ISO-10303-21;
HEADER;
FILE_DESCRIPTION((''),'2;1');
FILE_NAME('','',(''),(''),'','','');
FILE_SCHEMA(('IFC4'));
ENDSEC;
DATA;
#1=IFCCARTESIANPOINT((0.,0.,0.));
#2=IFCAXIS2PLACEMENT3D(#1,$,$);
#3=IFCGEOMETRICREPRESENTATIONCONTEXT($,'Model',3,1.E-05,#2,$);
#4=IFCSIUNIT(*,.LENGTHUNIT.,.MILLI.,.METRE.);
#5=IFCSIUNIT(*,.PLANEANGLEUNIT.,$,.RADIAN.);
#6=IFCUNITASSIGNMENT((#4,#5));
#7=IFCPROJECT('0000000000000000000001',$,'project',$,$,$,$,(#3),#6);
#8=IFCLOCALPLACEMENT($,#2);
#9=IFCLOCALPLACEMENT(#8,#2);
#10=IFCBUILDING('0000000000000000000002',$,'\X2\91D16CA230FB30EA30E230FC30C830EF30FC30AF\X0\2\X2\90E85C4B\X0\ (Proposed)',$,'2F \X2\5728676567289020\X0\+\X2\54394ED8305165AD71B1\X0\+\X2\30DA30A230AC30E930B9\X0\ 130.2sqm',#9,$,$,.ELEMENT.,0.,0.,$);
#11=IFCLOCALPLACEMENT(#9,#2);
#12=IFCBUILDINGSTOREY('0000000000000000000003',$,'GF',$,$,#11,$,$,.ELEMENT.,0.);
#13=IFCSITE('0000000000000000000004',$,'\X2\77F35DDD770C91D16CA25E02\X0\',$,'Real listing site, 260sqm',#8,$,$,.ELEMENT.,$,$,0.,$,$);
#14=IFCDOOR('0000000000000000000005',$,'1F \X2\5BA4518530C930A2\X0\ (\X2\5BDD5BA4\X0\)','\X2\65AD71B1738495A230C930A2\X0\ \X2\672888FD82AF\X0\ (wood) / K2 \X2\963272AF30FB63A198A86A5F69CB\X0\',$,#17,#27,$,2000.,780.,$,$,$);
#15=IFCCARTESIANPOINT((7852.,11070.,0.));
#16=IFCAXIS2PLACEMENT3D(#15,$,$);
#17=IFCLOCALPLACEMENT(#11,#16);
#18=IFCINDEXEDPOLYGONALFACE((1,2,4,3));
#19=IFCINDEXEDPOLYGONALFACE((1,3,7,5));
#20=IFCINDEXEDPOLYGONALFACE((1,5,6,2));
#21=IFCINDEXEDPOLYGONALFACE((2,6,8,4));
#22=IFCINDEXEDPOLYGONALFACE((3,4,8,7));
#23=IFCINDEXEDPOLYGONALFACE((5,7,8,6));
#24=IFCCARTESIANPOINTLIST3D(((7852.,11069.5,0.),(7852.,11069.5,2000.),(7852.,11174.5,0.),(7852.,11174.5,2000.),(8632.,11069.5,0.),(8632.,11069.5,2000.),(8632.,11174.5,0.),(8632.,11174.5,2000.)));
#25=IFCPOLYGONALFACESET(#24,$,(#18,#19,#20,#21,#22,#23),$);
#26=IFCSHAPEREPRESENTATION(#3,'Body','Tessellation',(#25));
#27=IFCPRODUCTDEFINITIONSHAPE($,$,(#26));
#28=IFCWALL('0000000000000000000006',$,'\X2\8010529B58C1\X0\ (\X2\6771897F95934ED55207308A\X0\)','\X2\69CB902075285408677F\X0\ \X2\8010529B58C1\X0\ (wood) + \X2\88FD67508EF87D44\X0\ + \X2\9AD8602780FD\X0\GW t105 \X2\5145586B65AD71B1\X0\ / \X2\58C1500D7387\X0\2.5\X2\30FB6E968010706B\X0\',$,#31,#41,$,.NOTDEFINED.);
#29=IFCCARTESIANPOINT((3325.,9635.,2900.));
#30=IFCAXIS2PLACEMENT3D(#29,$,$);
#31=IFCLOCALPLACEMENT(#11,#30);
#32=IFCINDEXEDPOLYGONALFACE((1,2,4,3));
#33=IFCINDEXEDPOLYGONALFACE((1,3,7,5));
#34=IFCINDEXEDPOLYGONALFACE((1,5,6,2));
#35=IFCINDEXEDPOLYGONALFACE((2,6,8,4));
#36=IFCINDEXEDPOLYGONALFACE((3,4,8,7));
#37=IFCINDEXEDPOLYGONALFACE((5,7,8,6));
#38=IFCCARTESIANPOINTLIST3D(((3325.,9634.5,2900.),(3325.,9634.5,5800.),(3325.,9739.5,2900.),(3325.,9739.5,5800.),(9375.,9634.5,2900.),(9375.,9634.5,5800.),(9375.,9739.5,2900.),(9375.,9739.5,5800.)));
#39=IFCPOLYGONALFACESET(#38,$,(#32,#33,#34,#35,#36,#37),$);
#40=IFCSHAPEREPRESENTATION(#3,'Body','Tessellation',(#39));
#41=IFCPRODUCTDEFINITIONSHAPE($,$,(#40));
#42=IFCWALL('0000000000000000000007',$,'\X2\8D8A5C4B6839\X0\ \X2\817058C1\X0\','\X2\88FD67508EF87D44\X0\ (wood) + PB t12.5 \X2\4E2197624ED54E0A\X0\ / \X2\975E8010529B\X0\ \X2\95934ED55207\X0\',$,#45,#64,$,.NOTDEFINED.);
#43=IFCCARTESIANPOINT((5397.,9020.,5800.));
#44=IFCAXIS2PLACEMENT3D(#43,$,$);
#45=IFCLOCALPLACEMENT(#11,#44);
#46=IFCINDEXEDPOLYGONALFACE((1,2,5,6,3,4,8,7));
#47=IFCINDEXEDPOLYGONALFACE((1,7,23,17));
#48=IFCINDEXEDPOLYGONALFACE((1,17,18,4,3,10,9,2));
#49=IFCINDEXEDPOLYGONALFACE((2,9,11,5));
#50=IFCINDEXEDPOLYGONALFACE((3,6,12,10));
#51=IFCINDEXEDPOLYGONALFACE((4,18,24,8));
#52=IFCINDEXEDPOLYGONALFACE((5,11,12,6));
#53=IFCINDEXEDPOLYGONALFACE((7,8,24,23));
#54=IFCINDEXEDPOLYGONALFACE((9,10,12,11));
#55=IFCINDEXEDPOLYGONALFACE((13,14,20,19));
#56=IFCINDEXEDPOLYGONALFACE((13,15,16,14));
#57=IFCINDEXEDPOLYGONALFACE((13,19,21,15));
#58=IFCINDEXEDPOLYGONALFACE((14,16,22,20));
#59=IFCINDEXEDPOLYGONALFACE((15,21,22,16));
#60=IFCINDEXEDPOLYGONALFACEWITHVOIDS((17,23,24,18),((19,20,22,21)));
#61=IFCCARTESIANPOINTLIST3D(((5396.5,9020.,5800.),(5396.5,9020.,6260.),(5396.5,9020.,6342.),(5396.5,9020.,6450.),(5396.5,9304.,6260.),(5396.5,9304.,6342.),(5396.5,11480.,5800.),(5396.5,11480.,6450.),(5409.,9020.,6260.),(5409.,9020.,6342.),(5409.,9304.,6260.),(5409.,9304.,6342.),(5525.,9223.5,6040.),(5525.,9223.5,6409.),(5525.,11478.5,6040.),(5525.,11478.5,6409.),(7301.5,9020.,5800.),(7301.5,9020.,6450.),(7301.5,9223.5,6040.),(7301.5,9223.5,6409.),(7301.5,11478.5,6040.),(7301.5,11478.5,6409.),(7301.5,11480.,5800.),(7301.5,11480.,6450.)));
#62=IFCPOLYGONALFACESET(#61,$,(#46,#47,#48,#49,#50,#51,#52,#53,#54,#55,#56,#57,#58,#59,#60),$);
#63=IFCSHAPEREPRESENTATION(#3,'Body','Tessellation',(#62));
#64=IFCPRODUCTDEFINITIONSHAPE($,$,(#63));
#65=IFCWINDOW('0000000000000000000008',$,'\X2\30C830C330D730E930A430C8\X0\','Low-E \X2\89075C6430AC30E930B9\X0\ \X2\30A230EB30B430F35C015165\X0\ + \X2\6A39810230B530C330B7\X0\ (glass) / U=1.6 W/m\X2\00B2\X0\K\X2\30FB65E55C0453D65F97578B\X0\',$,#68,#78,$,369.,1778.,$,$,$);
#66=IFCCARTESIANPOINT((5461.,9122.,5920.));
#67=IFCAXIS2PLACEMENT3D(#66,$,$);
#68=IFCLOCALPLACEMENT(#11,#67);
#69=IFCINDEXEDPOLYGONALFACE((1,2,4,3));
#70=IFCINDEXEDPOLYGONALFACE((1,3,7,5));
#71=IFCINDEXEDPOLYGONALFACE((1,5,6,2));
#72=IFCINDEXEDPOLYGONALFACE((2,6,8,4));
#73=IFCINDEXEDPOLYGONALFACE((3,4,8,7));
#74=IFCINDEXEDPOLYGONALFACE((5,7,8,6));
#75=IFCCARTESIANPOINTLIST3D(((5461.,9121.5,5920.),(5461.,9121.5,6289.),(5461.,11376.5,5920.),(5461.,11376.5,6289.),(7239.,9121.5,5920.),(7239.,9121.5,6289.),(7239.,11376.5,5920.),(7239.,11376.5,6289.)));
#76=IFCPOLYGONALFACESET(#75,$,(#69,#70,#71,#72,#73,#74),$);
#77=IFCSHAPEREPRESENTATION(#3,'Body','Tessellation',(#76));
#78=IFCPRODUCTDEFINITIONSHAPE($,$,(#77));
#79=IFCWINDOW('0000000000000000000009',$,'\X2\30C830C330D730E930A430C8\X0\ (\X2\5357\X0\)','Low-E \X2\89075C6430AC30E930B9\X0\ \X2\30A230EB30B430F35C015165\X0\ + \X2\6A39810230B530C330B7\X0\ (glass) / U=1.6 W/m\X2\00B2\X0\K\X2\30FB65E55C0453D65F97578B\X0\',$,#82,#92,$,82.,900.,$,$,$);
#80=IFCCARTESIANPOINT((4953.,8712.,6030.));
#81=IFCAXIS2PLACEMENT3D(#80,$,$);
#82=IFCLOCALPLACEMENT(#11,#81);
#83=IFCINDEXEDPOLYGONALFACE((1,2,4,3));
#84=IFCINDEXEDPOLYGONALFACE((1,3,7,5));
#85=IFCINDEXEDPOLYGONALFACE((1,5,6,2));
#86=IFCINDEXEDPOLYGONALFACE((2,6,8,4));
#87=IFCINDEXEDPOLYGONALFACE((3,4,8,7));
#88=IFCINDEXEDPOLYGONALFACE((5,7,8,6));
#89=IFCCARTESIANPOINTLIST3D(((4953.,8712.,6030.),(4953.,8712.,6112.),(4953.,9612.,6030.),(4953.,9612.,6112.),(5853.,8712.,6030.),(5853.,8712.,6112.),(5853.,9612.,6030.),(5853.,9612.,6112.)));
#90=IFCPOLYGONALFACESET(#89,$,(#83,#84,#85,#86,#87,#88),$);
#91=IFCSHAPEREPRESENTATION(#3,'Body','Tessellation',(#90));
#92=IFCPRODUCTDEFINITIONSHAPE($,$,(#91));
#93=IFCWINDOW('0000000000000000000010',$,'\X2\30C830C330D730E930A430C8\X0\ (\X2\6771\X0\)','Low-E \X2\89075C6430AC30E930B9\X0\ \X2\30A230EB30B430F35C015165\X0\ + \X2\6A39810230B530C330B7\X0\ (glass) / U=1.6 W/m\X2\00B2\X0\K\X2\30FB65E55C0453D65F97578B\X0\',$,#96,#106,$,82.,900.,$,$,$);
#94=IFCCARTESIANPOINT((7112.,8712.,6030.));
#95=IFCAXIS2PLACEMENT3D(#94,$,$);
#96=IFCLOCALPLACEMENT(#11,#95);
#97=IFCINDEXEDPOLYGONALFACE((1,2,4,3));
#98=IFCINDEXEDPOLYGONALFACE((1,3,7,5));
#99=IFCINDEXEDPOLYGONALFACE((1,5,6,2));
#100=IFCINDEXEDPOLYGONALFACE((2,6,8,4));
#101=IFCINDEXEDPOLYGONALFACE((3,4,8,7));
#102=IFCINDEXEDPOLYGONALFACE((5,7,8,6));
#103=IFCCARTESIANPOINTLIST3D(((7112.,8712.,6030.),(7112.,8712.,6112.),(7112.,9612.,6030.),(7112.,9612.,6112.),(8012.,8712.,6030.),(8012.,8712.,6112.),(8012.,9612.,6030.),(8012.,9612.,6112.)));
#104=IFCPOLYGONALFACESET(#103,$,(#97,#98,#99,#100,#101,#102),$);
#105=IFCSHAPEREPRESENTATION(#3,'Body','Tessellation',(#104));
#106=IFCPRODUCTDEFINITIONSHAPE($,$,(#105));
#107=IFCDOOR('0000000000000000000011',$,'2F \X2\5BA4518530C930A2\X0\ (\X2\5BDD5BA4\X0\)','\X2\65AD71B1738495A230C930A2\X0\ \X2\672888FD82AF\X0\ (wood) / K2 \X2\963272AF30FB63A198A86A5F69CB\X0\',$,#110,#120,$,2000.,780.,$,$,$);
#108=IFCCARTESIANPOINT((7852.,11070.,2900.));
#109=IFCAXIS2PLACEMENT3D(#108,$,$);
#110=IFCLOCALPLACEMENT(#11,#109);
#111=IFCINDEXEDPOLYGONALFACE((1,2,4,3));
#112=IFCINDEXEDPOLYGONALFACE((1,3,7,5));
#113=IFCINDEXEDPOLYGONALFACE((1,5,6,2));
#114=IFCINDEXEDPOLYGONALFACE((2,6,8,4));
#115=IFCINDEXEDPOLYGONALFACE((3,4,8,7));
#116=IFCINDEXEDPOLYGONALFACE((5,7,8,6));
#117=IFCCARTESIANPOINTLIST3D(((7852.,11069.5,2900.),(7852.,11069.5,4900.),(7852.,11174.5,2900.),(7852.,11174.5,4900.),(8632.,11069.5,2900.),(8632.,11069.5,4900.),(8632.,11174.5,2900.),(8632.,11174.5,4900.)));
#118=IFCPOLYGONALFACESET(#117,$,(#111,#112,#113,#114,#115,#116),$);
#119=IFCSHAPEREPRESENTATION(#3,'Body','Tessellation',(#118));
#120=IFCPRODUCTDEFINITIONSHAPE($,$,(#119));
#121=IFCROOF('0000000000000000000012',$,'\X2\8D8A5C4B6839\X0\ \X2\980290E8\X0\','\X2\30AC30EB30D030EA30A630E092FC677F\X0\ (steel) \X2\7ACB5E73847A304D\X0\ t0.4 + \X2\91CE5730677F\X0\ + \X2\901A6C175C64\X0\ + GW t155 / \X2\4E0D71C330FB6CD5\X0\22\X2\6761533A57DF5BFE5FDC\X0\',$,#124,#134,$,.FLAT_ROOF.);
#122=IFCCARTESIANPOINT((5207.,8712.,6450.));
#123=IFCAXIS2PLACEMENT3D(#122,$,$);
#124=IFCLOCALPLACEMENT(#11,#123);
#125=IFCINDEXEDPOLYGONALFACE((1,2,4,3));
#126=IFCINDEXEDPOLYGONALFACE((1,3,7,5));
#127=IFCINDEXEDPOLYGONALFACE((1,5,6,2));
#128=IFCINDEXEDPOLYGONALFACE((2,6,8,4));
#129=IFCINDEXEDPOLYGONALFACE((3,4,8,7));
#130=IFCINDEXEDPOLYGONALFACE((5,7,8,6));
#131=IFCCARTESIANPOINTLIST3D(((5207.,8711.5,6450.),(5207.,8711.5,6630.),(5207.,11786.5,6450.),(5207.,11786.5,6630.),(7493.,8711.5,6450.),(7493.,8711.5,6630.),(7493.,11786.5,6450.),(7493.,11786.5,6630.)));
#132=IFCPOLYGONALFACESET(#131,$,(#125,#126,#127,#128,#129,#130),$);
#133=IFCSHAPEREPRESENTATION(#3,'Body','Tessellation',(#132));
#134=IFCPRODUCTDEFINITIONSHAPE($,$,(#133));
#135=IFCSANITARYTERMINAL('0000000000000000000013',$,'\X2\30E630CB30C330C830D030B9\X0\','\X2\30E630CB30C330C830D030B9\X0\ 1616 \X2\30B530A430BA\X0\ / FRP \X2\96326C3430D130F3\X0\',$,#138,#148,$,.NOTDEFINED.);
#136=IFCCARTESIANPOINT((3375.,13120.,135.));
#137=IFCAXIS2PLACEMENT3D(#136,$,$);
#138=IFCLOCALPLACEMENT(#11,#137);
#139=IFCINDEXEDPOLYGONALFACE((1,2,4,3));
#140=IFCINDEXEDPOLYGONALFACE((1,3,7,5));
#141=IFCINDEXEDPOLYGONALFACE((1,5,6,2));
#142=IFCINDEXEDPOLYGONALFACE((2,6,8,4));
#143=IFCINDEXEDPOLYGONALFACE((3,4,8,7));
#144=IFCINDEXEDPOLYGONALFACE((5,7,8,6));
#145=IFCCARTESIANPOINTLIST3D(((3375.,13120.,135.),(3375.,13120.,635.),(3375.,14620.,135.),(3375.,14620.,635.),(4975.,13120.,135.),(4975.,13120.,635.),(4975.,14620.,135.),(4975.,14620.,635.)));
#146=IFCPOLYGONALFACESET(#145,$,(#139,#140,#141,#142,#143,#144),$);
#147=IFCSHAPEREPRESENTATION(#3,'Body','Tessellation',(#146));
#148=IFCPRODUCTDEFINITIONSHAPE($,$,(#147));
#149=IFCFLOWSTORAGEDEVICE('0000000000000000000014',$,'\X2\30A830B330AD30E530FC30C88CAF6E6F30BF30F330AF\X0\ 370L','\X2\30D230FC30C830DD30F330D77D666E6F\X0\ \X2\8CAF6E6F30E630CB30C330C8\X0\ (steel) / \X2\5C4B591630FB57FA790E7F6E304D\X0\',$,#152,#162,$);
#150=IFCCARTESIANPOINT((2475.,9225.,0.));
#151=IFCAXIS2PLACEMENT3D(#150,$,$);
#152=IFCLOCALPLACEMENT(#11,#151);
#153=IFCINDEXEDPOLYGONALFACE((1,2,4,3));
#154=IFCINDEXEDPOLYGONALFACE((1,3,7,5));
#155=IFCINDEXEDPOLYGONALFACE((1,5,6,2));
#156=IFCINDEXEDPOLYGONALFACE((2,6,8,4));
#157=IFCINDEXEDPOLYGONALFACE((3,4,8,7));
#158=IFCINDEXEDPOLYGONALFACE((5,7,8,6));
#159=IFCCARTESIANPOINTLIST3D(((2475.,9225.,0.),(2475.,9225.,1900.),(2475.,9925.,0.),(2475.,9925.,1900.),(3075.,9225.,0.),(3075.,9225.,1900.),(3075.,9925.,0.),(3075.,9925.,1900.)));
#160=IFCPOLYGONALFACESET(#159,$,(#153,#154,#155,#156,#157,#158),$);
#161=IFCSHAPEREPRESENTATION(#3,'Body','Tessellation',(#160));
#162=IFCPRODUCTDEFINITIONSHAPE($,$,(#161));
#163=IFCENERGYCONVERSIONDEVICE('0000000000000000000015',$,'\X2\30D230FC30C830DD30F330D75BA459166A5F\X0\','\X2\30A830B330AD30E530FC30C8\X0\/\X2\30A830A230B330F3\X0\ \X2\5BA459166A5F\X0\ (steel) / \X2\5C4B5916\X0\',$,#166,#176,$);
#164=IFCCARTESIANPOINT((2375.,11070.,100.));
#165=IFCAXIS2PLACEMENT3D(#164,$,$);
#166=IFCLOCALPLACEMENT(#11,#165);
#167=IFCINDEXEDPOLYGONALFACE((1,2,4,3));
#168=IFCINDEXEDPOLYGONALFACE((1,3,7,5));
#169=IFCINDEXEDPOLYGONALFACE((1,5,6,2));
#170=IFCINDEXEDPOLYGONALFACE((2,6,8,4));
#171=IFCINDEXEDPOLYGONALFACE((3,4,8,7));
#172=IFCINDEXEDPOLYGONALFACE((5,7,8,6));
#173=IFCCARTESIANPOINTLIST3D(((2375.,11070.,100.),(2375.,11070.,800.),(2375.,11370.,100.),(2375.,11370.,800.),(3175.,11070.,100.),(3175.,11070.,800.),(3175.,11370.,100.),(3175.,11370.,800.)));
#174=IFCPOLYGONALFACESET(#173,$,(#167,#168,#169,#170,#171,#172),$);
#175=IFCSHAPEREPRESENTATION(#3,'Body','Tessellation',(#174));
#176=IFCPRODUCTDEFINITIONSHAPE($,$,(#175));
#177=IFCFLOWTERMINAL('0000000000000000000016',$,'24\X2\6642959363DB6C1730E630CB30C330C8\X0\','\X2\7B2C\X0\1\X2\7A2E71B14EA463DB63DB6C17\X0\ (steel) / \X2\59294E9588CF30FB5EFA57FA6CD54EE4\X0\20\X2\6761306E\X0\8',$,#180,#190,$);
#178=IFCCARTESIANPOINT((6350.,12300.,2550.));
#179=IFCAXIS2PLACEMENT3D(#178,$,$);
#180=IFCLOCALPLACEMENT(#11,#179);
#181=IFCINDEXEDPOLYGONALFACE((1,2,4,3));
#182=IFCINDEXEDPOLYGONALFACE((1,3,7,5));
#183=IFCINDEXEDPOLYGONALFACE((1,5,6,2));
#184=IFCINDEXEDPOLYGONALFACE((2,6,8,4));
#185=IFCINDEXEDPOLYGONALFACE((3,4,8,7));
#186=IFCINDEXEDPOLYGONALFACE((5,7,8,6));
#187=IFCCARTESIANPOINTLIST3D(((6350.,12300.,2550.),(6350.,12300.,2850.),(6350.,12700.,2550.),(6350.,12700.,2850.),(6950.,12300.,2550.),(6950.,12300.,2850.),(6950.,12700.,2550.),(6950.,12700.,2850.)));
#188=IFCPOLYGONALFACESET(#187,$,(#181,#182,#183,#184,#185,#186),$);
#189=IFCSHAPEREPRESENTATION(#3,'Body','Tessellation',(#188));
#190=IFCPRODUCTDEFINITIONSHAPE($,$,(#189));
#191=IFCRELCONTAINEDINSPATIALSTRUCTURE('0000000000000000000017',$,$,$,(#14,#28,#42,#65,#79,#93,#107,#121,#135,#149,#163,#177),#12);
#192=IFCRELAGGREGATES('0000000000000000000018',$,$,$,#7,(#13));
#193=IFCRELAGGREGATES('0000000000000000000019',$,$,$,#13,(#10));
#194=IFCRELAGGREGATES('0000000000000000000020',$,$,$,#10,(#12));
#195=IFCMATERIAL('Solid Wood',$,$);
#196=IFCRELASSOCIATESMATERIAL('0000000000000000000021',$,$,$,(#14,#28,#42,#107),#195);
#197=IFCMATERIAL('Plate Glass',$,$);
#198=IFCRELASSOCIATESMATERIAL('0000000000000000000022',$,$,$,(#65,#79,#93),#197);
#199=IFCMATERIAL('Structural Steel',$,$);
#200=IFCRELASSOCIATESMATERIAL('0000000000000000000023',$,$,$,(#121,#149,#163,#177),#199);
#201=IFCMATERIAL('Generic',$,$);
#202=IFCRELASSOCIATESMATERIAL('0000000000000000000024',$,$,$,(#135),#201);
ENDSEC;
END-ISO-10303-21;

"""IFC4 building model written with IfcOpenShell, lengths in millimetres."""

from ifc_helpers import new_model, si_unit, frame, frame_2d, origin, place, context, project, spatial, rectangle, extrude, material, element, fill, save


model = new_model("IFC4")

# Units and contexts
model_context = context("Model", 3, precision=1e-05, world=origin())
ifc_project = project(units=[si_unit("LENGTHUNIT", "METRE", prefix="MILLI"), si_unit("PLANEANGLEUNIT", "RADIAN")], contexts=[model_context])

# Site, building, storey
site_placement = place(None, origin())
site = spatial("IfcSite", under=ifc_project, at=site_placement, Name="石川県金沢市", ObjectType="Real listing site, 260sqm", CompositionType="ELEMENT", RefElevation=0.0)
building_placement = place(site_placement, origin())
building = spatial("IfcBuilding", under=site, at=building_placement, Name="金沢・リモートワーク2部屋 (Proposed)", ObjectType="2F 在来木造+吹付け断熱+ペアガラス 130.2sqm", CompositionType="ELEMENT", ElevationOfRefHeight=0.0, ElevationOfTerrain=0.0)
storey_placement = place(building_placement, origin())
storey = spatial("IfcBuildingStorey", under=building, at=storey_placement, Name="GF", CompositionType="ELEMENT", Elevation=0.0)

# Shared definitions
ifc_material_1 = material(Name="Solid Wood")

# Door
door_1_placement = place(storey_placement, frame((7852.0, 11070.0, 0.0)))
element("IfcDoor", 1, at=door_1_placement, inside=storey, material=ifc_material_1, Name="1F 室内ドア (寝室)", Description="断熱玄関ドア 木製芯 (wood) / K2 防犯・採風機構", OverallHeight=2000.0, OverallWidth=780.0, context=model_context, shape_type="SweptSolid", body=[
    extrude(rectangle(XDim=780.0, YDim=105.0, at=frame_2d((390.0, 52.0))), frame((7852.0, 11070.0, 0.0)), (0.0, 0.0, 1.0), 2000.0),
])

# Wall
wall_1_placement = place(storey_placement, frame((3325.0, 9635.0, 2900.0)))
element("IfcWall", 2, at=wall_1_placement, inside=storey, material=ifc_material_1, Name="耐力壁 (東西間仕切り)", Description="構造用合板 耐力壁 (wood) + 製材軸組 + 高性能GW t105 充填断熱 / 壁倍率2.5・準耐火", PredefinedType="NOTDEFINED", context=model_context, shape_type="SweptSolid", body=[
    extrude(rectangle(XDim=6050.0, YDim=105.0, at=frame_2d((3025.0, 52.0))), frame((3325.0, 9635.0, 2900.0)), (0.0, 0.0, 1.0), 2900.0),
])

# Wall, openings, windows
wall_2_placement = place(storey_placement, frame((5397.0, 9020.0, 5800.0)))
wall_2 = element("IfcWall", 3, at=wall_2_placement, inside=storey, material=ifc_material_1, Name="越屋根 腰壁", Description="製材軸組 (wood) + PB t12.5 両面仕上 / 非耐力 間仕切", PredefinedType="NOTDEFINED", context=model_context, shape_type="SweptSolid", body=[
    extrude(rectangle(XDim=1905.0, YDim=2460.0, at=frame_2d((952.0, 1230.0))), frame((5397.0, 9020.0, 5800.0)), (0.0, 0.0, 1.0), 650.0),
])
opening_1_placement = place(storey_placement, frame((5461.0, 9122.0, 5920.0)))
opening_1 = element("IfcOpeningElement", 4, at=opening_1_placement, cuts=wall_2, PredefinedType="NOTDEFINED", context=model_context, shape_type="SweptSolid", body=[
    extrude(rectangle(XDim=1778.0, YDim=2255.0, at=frame_2d((889.0, 1127.0))), frame((5461.0, 9122.0, 5920.0)), (0.0, 0.0, 1.0), 369.0),
])
opening_2_placement = place(storey_placement, frame((4953.0, 8712.0, 6030.0)))
opening_2 = element("IfcOpeningElement", 5, at=opening_2_placement, cuts=wall_2, PredefinedType="NOTDEFINED", context=model_context, shape_type="SweptSolid", body=[
    extrude(rectangle(XDim=900.0, YDim=900.0, at=frame_2d((450.0, 450.0))), frame((4953.0, 8712.0, 6030.0)), (0.0, 0.0, 1.0), 82.0),
])
opening_3_placement = place(storey_placement, frame((7112.0, 8712.0, 6030.0)))
opening_3 = element("IfcOpeningElement", 6, at=opening_3_placement, cuts=wall_2, PredefinedType="NOTDEFINED", context=model_context, shape_type="SweptSolid", body=[
    extrude(rectangle(XDim=900.0, YDim=900.0, at=frame_2d((450.0, 450.0))), frame((7112.0, 8712.0, 6030.0)), (0.0, 0.0, 1.0), 82.0),
])
ifc_material_2 = material(Name="Plate Glass")
window_1_placement = place(storey_placement, frame((5461.0, 9122.0, 5920.0)))
window_1 = element("IfcWindow", 7, at=window_1_placement, inside=storey, material=ifc_material_2, Name="トップライト", Description="Low-E 複層ガラス アルゴン封入 + 樹脂サッシ (glass) / U=1.6 W/m²K・日射取得型", OverallHeight=369.0, OverallWidth=1778.0, context=model_context, shape_type="SweptSolid", body=[
    extrude(rectangle(XDim=1778.0, YDim=2255.0, at=frame_2d((889.0, 1127.0))), frame((5461.0, 9122.0, 5920.0)), (0.0, 0.0, 1.0), 369.0),
])
fill(opening_1, window_1)
window_2_placement = place(storey_placement, frame((4953.0, 8712.0, 6030.0)))
window_2 = element("IfcWindow", 8, at=window_2_placement, inside=storey, material=ifc_material_2, Name="トップライト (南)", Description="Low-E 複層ガラス アルゴン封入 + 樹脂サッシ (glass) / U=1.6 W/m²K・日射取得型", OverallHeight=82.0, OverallWidth=900.0, context=model_context, shape_type="SweptSolid", body=[
    extrude(rectangle(XDim=900.0, YDim=900.0, at=frame_2d((450.0, 450.0))), frame((4953.0, 8712.0, 6030.0)), (0.0, 0.0, 1.0), 82.0),
])
fill(opening_2, window_2)
window_3_placement = place(storey_placement, frame((7112.0, 8712.0, 6030.0)))
window_3 = element("IfcWindow", 9, at=window_3_placement, inside=storey, material=ifc_material_2, Name="トップライト (東)", Description="Low-E 複層ガラス アルゴン封入 + 樹脂サッシ (glass) / U=1.6 W/m²K・日射取得型", OverallHeight=82.0, OverallWidth=900.0, context=model_context, shape_type="SweptSolid", body=[
    extrude(rectangle(XDim=900.0, YDim=900.0, at=frame_2d((450.0, 450.0))), frame((7112.0, 8712.0, 6030.0)), (0.0, 0.0, 1.0), 82.0),
])
fill(opening_3, window_3)

# Door
door_2_placement = place(storey_placement, frame((7852.0, 11070.0, 2900.0)))
element("IfcDoor", 10, at=door_2_placement, inside=storey, material=ifc_material_1, Name="2F 室内ドア (寝室)", Description="断熱玄関ドア 木製芯 (wood) / K2 防犯・採風機構", OverallHeight=2000.0, OverallWidth=780.0, context=model_context, shape_type="SweptSolid", body=[
    extrude(rectangle(XDim=780.0, YDim=105.0, at=frame_2d((390.0, 52.0))), frame((7852.0, 11070.0, 2900.0)), (0.0, 0.0, 1.0), 2000.0),
])

# Roof
ifc_material_3 = material(Name="Structural Steel")
roof_placement = place(storey_placement, frame((5207.0, 8712.0, 6450.0)))
element("IfcRoof", 11, at=roof_placement, inside=storey, material=ifc_material_3, Name="越屋根 頂部", Description="ガルバリウム鋼板 (steel) 立平葺き t0.4 + 野地板 + 通気層 + GW t155 / 不燃・法22条区域対応", PredefinedType="FLAT_ROOF", context=model_context, shape_type="SweptSolid", body=[
    extrude(rectangle(XDim=2286.0, YDim=3075.0, at=frame_2d((1143.0, 1537.0))), frame((5207.0, 8712.0, 6450.0)), (0.0, 0.0, 1.0), 180.0),
])

# Sanitary terminal
ifc_material_4 = material(Name="Generic")
sanitary_terminal_placement = place(storey_placement, frame((3375.0, 13120.0, 135.0)))
element("IfcSanitaryTerminal", 12, at=sanitary_terminal_placement, inside=storey, material=ifc_material_4, Name="ユニットバス", Description="ユニットバス 1616 サイズ / FRP 防水パン", PredefinedType="NOTDEFINED", context=model_context, shape_type="SweptSolid", body=[
    extrude(rectangle(XDim=1600.0, YDim=1500.0, at=frame_2d((800.0, 750.0))), frame((3375.0, 13120.0, 135.0)), (0.0, 0.0, 1.0), 500.0),
])

# Flow storage device
flow_storage_device_placement = place(storey_placement, frame((2475.0, 9225.0, 0.0)))
element("IfcFlowStorageDevice", 13, at=flow_storage_device_placement, inside=storey, material=ifc_material_3, Name="エコキュート貯湯タンク 370L", Description="ヒートポンプ給湯 貯湯ユニット (steel) / 屋外・基礎置き", context=model_context, shape_type="SweptSolid", body=[
    extrude(rectangle(XDim=600.0, YDim=700.0, at=frame_2d((300.0, 350.0))), frame((2475.0, 9225.0, 0.0)), (0.0, 0.0, 1.0), 1900.0),
])

# Energy conversion device
energy_conversion_device_placement = place(storey_placement, frame((2375.0, 11070.0, 100.0)))
element("IfcEnergyConversionDevice", 14, at=energy_conversion_device_placement, inside=storey, material=ifc_material_3, Name="ヒートポンプ室外機", Description="エコキュート/エアコン 室外機 (steel) / 屋外", context=model_context, shape_type="SweptSolid", body=[
    extrude(rectangle(XDim=800.0, YDim=300.0, at=frame_2d((400.0, 150.0))), frame((2375.0, 11070.0, 100.0)), (0.0, 0.0, 1.0), 700.0),
])

# Flow terminal
flow_terminal_placement = place(storey_placement, frame((6350.0, 12300.0, 2550.0)))
element("IfcFlowTerminal", 15, at=flow_terminal_placement, inside=storey, material=ifc_material_3, Name="24時間換気ユニット", Description="第1種熱交換換気 (steel) / 天井裏・建基法令20条の8", context=model_context, shape_type="SweptSolid", body=[
    extrude(rectangle(XDim=600.0, YDim=400.0, at=frame_2d((300.0, 200.0))), frame((6350.0, 12300.0, 2550.0)), (0.0, 0.0, 1.0), 300.0),
])

save(model, "model.ifc")
